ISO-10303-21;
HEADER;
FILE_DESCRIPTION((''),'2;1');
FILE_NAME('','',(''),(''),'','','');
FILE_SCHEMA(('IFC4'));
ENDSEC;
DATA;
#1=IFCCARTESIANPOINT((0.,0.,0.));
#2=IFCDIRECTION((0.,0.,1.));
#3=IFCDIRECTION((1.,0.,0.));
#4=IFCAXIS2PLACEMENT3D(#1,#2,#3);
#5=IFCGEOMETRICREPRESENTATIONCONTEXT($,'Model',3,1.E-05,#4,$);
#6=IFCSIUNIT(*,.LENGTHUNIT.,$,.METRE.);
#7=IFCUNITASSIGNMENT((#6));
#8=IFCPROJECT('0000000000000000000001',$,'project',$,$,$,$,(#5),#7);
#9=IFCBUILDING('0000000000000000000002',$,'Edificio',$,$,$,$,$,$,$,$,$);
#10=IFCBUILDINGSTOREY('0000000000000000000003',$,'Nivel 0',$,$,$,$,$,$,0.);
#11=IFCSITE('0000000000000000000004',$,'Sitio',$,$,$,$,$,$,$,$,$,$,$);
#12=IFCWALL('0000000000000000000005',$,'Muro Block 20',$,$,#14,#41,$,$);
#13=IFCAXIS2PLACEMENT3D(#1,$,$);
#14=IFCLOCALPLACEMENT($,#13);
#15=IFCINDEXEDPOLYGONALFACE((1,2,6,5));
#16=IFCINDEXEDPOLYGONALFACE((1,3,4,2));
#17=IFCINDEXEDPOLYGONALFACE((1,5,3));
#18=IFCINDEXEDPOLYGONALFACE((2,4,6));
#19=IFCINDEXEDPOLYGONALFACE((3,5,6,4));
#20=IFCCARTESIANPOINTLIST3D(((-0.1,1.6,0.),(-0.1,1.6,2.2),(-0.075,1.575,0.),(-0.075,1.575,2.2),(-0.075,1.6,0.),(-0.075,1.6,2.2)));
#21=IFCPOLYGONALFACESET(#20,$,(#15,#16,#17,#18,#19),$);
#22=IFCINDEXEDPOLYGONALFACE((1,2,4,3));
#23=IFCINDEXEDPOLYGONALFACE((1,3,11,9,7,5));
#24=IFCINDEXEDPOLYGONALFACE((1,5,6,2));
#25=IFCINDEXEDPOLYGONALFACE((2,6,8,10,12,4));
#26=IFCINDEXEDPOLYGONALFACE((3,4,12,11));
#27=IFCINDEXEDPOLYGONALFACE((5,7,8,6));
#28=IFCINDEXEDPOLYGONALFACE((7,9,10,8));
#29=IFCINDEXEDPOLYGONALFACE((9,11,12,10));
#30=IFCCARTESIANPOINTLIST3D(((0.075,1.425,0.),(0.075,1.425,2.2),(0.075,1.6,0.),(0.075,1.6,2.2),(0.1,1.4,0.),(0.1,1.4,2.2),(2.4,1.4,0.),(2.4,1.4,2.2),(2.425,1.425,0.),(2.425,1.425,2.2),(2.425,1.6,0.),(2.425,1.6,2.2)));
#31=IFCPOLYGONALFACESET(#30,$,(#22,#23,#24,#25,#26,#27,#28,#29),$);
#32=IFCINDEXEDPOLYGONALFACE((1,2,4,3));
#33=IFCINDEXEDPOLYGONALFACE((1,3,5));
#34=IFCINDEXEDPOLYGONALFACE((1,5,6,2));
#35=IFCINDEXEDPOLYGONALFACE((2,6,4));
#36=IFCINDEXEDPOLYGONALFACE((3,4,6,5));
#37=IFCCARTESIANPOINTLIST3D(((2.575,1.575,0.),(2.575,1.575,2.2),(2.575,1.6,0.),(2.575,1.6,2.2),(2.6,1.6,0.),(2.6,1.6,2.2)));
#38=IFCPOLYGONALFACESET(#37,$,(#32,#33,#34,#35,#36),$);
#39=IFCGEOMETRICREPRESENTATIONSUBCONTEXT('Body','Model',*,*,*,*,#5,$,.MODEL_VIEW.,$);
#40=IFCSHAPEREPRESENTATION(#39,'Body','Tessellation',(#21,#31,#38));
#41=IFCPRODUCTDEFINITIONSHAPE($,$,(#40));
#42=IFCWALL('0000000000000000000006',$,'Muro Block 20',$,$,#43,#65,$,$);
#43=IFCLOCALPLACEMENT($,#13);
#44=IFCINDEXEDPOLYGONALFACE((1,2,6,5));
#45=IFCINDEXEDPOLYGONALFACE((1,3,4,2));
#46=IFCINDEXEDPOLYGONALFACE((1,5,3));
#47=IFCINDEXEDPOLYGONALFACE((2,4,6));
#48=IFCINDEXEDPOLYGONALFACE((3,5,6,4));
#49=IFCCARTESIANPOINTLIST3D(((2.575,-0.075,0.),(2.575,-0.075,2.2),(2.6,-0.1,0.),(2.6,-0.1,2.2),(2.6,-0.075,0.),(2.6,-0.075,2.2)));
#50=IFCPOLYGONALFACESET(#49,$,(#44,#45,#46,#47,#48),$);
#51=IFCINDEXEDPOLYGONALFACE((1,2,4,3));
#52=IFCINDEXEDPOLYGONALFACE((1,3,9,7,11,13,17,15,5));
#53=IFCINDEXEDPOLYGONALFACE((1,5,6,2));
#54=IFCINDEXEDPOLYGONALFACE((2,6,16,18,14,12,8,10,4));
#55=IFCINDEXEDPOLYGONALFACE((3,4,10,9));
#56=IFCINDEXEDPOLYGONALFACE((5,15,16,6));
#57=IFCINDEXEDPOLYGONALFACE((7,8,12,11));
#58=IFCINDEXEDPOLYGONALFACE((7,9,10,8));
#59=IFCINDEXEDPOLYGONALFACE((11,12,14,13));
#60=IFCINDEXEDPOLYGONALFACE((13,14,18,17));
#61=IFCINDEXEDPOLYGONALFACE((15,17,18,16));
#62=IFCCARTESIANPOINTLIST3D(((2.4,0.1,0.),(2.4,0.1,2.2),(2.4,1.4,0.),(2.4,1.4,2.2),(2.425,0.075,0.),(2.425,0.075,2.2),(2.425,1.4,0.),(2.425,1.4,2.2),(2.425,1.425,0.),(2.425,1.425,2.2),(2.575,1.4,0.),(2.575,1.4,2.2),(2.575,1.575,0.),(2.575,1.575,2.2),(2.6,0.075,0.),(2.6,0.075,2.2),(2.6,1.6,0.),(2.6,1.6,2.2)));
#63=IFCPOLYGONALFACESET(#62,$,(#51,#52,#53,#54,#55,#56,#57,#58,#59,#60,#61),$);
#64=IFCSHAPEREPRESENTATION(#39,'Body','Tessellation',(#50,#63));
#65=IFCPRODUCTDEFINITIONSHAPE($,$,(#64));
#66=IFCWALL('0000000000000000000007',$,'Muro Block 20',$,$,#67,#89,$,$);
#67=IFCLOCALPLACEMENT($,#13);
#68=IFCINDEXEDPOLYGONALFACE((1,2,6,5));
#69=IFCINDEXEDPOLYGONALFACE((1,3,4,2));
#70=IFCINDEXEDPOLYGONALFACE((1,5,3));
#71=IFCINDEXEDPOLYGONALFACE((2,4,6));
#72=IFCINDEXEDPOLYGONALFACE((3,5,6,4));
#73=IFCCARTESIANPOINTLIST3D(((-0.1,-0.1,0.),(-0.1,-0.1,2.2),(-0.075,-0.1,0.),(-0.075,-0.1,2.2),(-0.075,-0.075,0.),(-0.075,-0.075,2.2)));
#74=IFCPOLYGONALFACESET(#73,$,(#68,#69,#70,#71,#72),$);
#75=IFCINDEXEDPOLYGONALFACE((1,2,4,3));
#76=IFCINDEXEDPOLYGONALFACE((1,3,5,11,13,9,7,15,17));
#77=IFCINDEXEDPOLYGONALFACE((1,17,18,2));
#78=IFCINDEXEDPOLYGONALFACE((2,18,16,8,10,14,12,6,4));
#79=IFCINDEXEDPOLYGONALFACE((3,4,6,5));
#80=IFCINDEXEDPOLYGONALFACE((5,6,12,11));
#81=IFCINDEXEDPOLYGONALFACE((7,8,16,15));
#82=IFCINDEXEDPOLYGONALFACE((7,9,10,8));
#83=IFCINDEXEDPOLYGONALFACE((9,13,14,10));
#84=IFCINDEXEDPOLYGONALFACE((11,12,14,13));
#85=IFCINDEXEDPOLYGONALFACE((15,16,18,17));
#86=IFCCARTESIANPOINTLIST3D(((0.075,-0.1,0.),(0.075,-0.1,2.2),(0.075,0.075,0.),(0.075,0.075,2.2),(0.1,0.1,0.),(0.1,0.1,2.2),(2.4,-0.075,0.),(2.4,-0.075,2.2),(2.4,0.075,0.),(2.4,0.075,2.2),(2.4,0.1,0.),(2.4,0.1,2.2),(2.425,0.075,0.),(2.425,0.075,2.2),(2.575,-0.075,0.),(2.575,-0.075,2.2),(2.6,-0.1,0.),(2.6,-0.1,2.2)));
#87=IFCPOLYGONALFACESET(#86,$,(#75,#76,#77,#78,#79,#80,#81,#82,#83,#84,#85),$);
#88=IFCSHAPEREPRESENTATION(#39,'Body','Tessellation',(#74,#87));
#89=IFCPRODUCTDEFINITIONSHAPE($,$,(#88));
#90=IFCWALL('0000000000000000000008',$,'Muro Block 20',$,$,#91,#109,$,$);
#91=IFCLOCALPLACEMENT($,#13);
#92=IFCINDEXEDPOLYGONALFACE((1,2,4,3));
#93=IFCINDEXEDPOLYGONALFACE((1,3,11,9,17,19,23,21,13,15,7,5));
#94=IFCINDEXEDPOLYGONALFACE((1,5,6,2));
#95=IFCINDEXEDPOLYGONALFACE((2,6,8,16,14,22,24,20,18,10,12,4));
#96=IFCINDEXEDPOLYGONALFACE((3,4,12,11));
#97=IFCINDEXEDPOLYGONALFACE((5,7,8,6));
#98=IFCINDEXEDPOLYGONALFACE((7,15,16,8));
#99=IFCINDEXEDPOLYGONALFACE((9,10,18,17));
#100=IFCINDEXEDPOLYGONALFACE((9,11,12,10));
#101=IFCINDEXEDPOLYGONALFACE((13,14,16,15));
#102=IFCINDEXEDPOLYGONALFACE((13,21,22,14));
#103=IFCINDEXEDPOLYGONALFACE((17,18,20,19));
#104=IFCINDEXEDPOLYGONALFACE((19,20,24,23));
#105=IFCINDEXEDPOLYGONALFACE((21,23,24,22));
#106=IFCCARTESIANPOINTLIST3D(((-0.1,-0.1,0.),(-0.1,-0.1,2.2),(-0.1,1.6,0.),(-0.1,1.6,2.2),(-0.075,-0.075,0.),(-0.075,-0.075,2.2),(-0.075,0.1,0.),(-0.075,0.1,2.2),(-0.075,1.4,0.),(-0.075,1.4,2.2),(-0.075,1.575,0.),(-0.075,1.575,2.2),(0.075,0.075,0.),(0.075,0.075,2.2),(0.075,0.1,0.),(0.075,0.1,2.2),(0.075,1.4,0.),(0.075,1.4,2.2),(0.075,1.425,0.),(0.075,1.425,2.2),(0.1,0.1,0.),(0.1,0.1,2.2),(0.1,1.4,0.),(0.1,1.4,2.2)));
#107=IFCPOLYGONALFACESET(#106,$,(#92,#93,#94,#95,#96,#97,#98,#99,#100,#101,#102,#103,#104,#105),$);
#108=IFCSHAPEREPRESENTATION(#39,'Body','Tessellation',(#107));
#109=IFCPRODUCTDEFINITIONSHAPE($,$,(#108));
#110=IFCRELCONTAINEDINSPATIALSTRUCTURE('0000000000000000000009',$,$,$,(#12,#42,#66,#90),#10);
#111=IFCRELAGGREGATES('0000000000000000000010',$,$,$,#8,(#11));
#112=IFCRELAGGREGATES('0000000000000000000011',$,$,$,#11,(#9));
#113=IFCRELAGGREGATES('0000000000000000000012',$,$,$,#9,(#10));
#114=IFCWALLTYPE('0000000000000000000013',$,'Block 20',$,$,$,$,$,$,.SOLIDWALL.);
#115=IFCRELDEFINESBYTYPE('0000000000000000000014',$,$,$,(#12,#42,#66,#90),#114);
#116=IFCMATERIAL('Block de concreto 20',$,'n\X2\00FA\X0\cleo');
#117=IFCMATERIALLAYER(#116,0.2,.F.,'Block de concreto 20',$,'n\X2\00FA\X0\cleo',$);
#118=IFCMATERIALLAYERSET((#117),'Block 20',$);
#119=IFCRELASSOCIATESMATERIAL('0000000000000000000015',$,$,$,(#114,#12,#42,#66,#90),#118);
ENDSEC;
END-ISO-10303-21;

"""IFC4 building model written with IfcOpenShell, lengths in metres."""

from ifc_helpers import new_model, si_unit, frame, origin_with_axes, place, context, subcontext, project, spatial, indexed_curve, outline, extrude, material, layer, layer_set, layer_usage, type_object, element, save


model = new_model("IFC4")

# Units and contexts
model_context = context("Model", 3, precision=1e-05, world=origin_with_axes())
body_context = subcontext(model_context, "Body", "Model", "MODEL_VIEW")
ifc_project = project(units=[si_unit("LENGTHUNIT", "METRE")], contexts=[model_context])

# Site, building, storey
site = spatial("IfcSite", under=ifc_project, Name="Sitio")
building = spatial("IfcBuilding", under=site, Name="Edificio")
storey = spatial("IfcBuildingStorey", under=building, Name="Nivel 0", Elevation=0.0)

# Walls
ifc_material = material(Name="Block de concreto 20", Category="núcleo")
ifc_layer = layer(ifc_material, 0.2, ventilated=False, Name="Block de concreto 20", Category="núcleo")
ifc_layer_set = layer_set([ifc_layer], Name="Block 20")
ifc_layer_usage_1 = layer_usage(ifc_layer_set, "AXIS2", "POSITIVE", 0.0)
wall_type = type_object("IfcWallType", Name="Block 20", PredefinedType="SOLIDWALL", material=ifc_layer_set)
wall_1_placement = place(None, frame((0.0, 1.5, 0.0), z_axis=(0.0, 0.0, 1.0), x_axis=(1.0, 0.0, 0.0)))
element("IfcWall", 1, at=wall_1_placement, inside=storey, type_object=wall_type, material=ifc_layer_usage_1, Name="Muro Block 20", context=body_context, shape_type="SweptSolid", body=[
    extrude(outline(indexed_curve([(-0.075, 0.1), (-0.075, 0.075), (-0.1, 0.1)])), None, (0.0, 0.0, 1.0), 2.2),
    extrude(outline(indexed_curve([(2.4, -0.1), (0.1, -0.1), (0.075, -0.075), (0.075, 0.1), (2.425, 0.1), (2.425, -0.075)])), None, (0.0, 0.0, 1.0), 2.2),
    extrude(outline(indexed_curve([(2.575, 0.075), (2.575, 0.1), (2.6, 0.1)])), None, (0.0, 0.0, 1.0), 2.2),
])
ifc_layer_usage_2 = layer_usage(ifc_layer_set, "AXIS2", "POSITIVE", 0.0)
wall_2_placement = place(None, frame((2.5, 1.5, 0.0), z_axis=(0.0, 0.0, 1.0), x_axis=(0.0, -1.0, 0.0)))
element("IfcWall", 2, at=wall_2_placement, inside=storey, type_object=wall_type, material=ifc_layer_usage_2, Name="Muro Block 20", context=body_context, shape_type="SweptSolid", body=[
    extrude(outline(indexed_curve([(1.6, 0.1), (1.575, 0.075), (1.575, 0.1)])), None, (0.0, 0.0, 1.0), 2.2),
    extrude(outline(indexed_curve([(1.425, 0.1), (1.425, -0.075), (1.4, -0.1), (0.1, -0.1), (0.075, -0.075), (0.1, -0.075), (0.1, 0.075), (-0.075, 0.075), (-0.1, 0.1)])), None, (0.0, 0.0, 1.0), 2.2),
])
ifc_layer_usage_3 = layer_usage(ifc_layer_set, "AXIS2", "POSITIVE", 0.0)
wall_3_placement = place(None, frame((2.5, 0.0, 0.0), z_axis=(0.0, 0.0, 1.0), x_axis=(-1.0, 0.0, 0.0)))
element("IfcWall", 3, at=wall_3_placement, inside=storey, type_object=wall_type, material=ifc_layer_usage_3, Name="Muro Block 20", context=body_context, shape_type="SweptSolid", body=[
    extrude(outline(indexed_curve([(2.6, 0.1), (2.575, 0.075), (2.575, 0.1)])), None, (0.0, 0.0, 1.0), 2.2),
    extrude(outline(indexed_curve([(2.425, 0.1), (2.425, -0.075), (2.4, -0.1), (0.1, -0.1), (0.075, -0.075), (0.1, -0.075), (0.1, 0.075), (-0.075, 0.075), (-0.1, 0.1)])), None, (0.0, 0.0, 1.0), 2.2),
])
ifc_layer_usage_4 = layer_usage(ifc_layer_set, "AXIS2", "POSITIVE", 0.0)
wall_4_placement = place(None, frame((0.0, 0.0, 0.0), z_axis=(0.0, 0.0, 1.0), x_axis=(0.0, 1.0, 0.0)))
element("IfcWall", 4, at=wall_4_placement, inside=storey, type_object=wall_type, material=ifc_layer_usage_4, Name="Muro Block 20", context=body_context, shape_type="SweptSolid", body=[
    extrude(outline(indexed_curve([(0.1, -0.1), (0.075, -0.075), (0.1, -0.075), (0.1, 0.075), (-0.075, 0.075), (-0.1, 0.1), (1.6, 0.1), (1.575, 0.075), (1.4, 0.075), (1.4, -0.075), (1.425, -0.075), (1.4, -0.1)])), None, (0.0, 0.0, 1.0), 2.2),
])

save(model, "model.ifc")
